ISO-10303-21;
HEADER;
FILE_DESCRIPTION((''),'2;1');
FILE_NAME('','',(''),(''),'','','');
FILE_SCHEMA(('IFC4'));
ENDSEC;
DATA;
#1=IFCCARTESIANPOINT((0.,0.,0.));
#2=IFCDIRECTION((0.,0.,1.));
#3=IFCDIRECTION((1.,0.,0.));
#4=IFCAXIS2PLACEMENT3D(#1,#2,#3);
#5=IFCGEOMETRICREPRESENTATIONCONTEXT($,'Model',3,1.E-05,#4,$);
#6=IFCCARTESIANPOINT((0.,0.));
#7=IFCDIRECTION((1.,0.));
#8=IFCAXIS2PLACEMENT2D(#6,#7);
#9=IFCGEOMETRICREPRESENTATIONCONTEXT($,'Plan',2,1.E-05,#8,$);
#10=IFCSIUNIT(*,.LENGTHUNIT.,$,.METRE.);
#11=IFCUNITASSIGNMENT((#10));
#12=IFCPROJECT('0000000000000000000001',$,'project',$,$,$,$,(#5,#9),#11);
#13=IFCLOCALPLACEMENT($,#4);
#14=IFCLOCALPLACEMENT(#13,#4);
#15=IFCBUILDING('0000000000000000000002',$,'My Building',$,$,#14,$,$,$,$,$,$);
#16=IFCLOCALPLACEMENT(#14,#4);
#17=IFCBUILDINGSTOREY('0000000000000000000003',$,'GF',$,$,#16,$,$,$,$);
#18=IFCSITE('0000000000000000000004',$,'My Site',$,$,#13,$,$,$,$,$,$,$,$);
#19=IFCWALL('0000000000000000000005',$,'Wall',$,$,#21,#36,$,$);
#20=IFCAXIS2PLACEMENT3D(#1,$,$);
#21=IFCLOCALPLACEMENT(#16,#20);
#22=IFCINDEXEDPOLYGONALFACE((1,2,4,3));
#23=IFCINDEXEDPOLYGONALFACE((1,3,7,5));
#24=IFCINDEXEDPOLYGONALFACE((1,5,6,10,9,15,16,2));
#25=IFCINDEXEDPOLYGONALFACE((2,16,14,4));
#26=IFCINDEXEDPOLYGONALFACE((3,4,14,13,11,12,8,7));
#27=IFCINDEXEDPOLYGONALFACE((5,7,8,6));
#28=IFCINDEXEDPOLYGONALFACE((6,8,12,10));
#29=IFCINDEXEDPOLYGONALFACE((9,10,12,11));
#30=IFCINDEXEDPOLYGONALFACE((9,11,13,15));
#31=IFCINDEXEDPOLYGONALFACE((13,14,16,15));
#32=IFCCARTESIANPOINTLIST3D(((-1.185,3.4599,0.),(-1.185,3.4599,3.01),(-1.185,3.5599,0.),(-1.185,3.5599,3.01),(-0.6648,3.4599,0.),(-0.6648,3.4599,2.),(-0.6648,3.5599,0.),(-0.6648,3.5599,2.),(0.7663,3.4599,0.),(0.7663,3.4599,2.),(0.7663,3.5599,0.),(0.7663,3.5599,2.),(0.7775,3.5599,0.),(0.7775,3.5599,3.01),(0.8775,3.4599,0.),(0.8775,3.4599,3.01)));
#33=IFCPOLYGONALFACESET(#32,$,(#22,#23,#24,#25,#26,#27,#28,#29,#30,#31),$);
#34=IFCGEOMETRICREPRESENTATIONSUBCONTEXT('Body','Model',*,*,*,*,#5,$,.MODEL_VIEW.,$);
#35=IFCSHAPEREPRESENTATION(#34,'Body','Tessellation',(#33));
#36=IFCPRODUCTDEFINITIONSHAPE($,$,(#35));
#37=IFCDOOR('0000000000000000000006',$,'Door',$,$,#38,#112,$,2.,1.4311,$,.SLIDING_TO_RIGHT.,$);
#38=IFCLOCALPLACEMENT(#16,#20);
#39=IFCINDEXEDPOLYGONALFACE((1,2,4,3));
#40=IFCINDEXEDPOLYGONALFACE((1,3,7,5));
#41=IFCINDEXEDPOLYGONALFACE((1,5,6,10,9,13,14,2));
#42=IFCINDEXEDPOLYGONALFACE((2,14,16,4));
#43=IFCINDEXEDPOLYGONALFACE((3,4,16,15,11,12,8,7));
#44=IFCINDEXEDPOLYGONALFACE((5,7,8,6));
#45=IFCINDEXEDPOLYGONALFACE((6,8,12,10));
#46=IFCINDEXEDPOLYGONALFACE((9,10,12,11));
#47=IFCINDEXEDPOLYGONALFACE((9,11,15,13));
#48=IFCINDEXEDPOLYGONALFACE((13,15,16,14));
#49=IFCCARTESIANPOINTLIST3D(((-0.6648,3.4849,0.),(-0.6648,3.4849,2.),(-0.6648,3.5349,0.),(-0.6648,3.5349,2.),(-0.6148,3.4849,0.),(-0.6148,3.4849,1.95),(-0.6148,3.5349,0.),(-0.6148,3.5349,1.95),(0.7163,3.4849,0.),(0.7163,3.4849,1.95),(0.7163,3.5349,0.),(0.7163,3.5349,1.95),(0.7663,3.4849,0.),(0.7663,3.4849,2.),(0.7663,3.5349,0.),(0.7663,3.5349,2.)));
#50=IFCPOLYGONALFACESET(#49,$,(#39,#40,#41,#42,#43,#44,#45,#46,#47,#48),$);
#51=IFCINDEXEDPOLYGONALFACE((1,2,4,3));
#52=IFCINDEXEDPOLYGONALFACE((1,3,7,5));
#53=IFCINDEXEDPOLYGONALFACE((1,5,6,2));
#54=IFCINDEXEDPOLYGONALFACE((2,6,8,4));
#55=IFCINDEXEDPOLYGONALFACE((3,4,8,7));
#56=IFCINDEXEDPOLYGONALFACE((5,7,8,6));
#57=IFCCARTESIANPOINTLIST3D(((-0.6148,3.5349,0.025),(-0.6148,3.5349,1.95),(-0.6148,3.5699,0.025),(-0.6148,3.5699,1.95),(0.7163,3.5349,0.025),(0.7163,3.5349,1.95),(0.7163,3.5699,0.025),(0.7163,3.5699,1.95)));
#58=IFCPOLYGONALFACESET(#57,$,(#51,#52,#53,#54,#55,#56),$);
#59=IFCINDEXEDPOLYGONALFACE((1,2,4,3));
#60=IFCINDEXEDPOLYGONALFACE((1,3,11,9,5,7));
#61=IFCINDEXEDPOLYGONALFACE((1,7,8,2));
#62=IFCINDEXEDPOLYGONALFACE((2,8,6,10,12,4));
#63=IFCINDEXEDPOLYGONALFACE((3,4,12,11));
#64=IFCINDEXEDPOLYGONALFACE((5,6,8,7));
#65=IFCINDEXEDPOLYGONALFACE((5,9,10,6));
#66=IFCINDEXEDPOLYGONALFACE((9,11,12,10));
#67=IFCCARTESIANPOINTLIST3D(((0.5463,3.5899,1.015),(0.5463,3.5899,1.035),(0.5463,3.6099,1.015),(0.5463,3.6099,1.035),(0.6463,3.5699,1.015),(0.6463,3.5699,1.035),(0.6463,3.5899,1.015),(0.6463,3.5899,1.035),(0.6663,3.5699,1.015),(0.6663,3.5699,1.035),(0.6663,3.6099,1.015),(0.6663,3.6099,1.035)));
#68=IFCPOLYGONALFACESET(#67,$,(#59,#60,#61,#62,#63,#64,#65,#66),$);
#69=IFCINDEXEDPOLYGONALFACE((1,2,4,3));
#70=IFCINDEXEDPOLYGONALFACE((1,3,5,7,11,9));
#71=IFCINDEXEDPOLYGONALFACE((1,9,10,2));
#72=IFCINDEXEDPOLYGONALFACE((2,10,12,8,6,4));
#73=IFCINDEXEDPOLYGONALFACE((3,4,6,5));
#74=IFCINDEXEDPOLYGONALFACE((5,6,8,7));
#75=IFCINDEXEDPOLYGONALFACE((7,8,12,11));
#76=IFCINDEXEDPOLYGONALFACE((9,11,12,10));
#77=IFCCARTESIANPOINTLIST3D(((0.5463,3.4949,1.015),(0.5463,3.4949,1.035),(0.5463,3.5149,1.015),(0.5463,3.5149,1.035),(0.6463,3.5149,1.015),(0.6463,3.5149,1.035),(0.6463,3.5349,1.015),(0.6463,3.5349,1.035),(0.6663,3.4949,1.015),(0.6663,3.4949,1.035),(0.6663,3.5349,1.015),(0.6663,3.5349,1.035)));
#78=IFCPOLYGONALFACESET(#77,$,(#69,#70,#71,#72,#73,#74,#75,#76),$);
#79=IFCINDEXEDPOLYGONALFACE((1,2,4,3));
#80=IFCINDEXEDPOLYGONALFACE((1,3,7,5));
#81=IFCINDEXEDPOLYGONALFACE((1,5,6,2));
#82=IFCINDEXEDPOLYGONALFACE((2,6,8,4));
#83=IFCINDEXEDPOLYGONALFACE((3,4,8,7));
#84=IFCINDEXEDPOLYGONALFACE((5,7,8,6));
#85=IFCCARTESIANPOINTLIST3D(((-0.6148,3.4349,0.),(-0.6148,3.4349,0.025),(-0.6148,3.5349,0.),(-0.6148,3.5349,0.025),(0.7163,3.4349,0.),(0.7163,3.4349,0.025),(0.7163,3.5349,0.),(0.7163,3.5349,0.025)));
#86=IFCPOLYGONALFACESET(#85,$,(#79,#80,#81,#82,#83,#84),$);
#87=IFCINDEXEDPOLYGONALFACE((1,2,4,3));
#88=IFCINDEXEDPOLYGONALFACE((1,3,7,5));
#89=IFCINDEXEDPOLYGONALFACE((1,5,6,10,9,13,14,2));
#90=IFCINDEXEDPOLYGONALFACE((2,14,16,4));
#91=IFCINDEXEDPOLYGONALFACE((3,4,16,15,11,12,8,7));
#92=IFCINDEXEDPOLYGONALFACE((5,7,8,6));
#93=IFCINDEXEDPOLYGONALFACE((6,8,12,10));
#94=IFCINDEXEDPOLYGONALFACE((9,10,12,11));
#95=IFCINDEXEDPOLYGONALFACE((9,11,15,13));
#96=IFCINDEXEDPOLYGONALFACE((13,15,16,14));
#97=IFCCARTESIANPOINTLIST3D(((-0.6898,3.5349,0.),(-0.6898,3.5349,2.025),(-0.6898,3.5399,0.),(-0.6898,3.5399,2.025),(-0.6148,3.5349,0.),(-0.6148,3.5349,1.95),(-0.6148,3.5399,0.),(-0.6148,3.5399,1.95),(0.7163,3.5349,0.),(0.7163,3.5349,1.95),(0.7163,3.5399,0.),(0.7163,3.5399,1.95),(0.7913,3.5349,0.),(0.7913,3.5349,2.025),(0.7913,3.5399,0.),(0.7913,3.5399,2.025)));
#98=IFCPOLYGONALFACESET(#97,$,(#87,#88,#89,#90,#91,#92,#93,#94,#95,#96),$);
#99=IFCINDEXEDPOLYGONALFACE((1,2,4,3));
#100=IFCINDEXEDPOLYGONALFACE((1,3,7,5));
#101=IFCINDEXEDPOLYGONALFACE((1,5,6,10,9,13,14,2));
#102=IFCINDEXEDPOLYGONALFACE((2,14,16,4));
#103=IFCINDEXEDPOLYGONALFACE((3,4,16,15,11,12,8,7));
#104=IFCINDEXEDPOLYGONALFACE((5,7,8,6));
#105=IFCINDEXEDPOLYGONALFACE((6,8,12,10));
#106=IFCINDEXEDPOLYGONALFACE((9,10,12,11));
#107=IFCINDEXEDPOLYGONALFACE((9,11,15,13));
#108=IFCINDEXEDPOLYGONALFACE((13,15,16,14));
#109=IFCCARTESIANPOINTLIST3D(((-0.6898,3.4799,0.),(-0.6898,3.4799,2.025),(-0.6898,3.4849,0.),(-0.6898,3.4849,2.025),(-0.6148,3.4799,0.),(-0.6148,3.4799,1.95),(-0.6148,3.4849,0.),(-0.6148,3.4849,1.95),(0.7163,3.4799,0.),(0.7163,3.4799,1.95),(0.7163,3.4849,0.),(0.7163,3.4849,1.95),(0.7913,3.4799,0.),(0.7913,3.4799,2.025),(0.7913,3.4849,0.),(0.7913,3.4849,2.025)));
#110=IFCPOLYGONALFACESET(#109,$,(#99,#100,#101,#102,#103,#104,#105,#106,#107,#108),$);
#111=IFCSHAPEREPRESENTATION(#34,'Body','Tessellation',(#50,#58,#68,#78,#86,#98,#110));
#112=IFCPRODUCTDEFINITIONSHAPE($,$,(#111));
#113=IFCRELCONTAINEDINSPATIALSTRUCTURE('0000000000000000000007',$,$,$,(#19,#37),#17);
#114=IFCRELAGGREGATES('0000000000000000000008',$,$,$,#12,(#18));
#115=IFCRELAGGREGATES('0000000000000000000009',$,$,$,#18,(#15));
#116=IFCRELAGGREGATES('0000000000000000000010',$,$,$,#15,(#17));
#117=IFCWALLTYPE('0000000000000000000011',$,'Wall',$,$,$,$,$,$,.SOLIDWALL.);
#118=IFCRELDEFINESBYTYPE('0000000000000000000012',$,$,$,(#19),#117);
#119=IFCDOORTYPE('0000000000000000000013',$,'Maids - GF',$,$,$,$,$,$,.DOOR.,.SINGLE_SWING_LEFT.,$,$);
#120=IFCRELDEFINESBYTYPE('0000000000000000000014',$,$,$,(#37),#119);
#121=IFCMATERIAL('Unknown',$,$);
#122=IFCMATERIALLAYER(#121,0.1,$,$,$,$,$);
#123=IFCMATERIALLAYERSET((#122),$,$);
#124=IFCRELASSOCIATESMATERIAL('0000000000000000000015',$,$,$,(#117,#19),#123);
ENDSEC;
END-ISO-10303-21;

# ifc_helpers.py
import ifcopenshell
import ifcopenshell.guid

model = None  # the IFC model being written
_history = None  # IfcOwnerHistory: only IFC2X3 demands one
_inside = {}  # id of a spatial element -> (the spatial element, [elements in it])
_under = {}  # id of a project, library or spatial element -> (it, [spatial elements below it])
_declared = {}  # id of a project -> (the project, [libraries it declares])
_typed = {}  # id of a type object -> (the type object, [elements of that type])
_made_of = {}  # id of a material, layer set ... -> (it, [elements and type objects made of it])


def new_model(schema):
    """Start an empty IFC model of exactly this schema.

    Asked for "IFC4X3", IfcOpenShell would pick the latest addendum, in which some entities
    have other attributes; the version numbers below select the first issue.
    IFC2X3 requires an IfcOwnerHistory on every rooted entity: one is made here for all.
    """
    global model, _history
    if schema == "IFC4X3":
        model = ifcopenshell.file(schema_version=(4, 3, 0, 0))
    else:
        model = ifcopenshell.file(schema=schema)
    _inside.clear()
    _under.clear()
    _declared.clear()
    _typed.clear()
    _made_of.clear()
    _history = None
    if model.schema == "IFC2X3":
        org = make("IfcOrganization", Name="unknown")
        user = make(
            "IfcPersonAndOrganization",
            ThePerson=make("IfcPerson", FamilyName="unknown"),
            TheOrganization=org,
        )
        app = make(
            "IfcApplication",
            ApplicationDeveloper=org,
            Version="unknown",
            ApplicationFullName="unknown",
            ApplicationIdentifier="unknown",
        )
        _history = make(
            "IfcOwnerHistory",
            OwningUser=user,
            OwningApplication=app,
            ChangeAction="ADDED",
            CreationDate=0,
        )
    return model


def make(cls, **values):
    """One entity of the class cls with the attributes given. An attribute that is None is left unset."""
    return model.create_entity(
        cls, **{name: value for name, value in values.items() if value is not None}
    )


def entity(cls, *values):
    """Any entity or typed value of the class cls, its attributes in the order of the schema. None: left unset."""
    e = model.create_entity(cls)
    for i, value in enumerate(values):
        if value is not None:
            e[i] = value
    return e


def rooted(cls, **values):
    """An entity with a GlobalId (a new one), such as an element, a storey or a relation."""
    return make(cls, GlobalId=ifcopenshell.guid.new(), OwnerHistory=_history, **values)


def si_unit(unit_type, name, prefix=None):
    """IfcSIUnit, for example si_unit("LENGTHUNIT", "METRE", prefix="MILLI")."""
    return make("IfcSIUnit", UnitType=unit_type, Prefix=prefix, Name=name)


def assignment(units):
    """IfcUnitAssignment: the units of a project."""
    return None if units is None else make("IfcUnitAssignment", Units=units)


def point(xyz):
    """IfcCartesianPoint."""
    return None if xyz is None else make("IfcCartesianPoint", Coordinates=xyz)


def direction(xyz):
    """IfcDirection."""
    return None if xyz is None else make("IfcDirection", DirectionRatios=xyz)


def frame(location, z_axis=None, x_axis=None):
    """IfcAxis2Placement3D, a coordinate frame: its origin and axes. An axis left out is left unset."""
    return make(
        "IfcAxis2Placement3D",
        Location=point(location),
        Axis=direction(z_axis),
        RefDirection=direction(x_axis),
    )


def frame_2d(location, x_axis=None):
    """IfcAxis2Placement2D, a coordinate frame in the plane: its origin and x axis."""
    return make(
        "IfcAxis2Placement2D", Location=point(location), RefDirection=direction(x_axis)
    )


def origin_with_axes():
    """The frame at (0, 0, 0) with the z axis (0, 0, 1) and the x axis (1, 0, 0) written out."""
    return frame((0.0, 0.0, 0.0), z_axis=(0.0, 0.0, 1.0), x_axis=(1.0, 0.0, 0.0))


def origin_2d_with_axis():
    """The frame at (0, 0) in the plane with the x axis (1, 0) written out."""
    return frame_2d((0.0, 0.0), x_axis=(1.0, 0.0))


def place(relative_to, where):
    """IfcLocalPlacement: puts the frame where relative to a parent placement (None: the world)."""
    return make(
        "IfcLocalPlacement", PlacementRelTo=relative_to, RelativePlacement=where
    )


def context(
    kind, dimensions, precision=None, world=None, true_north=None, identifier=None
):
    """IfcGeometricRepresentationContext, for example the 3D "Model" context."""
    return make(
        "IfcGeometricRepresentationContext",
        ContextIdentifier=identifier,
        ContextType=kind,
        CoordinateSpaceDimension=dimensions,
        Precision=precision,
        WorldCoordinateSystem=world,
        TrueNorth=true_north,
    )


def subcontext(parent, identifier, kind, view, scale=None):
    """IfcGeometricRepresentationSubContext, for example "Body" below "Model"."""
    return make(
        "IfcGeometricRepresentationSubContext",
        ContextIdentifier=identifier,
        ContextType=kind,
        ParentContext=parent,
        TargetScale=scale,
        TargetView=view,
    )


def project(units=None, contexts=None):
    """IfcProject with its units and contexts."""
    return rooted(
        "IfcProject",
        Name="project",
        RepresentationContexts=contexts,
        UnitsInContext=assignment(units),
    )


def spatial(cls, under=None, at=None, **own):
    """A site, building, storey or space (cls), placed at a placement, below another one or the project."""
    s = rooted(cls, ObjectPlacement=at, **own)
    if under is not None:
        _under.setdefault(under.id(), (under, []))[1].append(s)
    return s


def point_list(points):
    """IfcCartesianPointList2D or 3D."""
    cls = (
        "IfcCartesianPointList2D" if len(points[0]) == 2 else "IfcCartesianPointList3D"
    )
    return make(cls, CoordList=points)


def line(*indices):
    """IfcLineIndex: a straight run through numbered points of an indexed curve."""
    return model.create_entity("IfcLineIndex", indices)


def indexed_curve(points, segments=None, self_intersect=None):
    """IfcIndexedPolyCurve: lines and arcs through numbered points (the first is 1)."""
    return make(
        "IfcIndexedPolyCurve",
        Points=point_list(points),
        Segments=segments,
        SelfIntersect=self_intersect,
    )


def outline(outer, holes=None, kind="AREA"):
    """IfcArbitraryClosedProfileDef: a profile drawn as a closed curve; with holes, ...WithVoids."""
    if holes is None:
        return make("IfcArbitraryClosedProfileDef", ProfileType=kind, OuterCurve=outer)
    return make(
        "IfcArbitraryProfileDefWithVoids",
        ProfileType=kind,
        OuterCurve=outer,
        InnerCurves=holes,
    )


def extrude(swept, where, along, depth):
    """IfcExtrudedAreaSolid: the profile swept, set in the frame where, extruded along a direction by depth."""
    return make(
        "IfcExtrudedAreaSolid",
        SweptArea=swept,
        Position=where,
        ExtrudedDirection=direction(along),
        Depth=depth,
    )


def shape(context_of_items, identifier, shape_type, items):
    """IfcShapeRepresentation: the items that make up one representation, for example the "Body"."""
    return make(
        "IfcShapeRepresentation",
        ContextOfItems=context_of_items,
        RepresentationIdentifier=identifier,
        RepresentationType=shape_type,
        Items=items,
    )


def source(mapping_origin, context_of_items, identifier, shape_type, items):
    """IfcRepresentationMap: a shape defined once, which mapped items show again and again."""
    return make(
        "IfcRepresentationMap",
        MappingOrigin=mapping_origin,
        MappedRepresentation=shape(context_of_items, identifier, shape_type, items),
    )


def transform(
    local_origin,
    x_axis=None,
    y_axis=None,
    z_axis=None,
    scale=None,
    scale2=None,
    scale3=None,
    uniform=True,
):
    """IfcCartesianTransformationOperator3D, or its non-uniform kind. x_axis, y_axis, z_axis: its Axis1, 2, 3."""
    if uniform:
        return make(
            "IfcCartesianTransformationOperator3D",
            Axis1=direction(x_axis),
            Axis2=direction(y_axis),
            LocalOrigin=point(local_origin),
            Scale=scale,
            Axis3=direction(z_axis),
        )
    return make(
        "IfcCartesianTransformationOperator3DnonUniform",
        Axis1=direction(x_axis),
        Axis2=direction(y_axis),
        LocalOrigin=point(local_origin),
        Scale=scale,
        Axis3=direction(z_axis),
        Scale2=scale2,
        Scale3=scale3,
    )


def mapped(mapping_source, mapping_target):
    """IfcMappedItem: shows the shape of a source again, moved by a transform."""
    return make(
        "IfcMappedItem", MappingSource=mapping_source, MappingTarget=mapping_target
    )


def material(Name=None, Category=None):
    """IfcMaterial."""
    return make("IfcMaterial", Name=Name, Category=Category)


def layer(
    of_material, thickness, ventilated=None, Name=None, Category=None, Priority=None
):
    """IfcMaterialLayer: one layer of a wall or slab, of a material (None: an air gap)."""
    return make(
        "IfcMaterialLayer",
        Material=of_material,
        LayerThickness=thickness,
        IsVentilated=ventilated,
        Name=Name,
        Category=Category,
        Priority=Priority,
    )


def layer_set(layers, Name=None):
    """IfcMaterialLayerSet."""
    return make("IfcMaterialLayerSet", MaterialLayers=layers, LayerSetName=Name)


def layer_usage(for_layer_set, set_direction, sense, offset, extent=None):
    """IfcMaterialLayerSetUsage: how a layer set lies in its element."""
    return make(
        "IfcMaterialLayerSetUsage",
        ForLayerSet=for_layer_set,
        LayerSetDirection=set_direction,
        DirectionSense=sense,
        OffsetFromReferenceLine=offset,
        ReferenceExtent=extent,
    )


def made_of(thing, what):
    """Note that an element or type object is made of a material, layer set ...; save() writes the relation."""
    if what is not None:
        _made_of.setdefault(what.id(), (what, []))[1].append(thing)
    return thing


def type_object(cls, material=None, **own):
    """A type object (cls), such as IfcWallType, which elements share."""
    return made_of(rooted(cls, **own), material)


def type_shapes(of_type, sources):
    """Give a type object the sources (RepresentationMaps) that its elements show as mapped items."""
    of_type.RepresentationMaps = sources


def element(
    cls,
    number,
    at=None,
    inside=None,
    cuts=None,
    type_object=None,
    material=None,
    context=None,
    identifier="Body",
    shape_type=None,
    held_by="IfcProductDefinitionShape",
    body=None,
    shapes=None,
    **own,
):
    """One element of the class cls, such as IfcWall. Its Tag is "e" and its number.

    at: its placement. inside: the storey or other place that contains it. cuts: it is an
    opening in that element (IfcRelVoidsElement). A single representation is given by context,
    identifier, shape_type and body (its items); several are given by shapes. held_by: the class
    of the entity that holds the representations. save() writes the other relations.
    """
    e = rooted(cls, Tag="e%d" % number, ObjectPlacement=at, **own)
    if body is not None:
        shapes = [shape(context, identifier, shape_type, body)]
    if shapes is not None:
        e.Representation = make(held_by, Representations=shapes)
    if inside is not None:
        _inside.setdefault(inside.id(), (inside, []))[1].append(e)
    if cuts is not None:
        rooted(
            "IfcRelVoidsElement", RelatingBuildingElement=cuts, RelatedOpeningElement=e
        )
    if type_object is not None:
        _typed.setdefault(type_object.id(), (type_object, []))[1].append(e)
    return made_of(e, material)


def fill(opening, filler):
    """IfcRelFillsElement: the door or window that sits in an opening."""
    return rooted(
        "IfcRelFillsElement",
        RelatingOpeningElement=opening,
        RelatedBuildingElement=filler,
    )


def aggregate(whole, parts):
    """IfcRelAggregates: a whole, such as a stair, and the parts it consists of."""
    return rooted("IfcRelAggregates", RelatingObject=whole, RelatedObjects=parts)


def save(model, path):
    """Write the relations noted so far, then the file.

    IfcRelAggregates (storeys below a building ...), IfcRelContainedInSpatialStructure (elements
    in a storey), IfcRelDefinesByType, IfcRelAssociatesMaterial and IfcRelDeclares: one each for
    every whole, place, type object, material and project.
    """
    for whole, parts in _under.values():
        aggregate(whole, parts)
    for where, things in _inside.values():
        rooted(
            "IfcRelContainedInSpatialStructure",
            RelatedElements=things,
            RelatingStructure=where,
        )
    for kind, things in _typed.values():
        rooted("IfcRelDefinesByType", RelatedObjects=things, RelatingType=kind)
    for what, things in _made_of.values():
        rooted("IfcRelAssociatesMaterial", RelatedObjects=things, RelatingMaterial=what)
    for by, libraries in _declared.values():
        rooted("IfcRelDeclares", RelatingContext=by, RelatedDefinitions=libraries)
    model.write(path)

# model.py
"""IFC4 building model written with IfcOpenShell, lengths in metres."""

from ifc_helpers import new_model, entity, si_unit, frame, origin_with_axes, origin_2d_with_axis, place, context, subcontext, project, spatial, line, indexed_curve, outline, extrude, shape, source, transform, mapped, material, layer, layer_set, layer_usage, type_object, type_shapes, element, fill, save


model = new_model("IFC4")

# Units and contexts
model_context = context("Model", 3, precision=1e-05, world=origin_with_axes())
plan_context = context("Plan", 2, precision=1e-05, world=origin_2d_with_axis())
body_context_1 = subcontext(model_context, "Body", "Model", "MODEL_VIEW")
body_context_2 = subcontext(plan_context, "Body", "Plan", "PLAN_VIEW")
ifc_project = project(units=[si_unit("LENGTHUNIT", "METRE")], contexts=[model_context, plan_context])

# Site, building, storey
site_placement = place(None, origin_with_axes())
site = spatial("IfcSite", under=ifc_project, at=site_placement, Name="My Site")
building_placement = place(site_placement, origin_with_axes())
building = spatial("IfcBuilding", under=site, at=building_placement, Name="My Building")
storey_placement = place(building_placement, origin_with_axes())
storey = spatial("IfcBuildingStorey", under=building, at=storey_placement, Name="GF")

# Shared definitions
ifc_material_1 = material(Name="Unknown")

# Shared definitions
ifc_layer_1 = layer(ifc_material_1, 0.1)
ifc_layer_set_1 = layer_set([ifc_layer_1])
wall_type = type_object("IfcWallType", Name="Wall", PredefinedType="SOLIDWALL", material=ifc_layer_set_1)

# Wall, opening, door
ifc_layer_usage_1 = layer_usage(ifc_layer_set_1, "AXIS2", "POSITIVE", 0.0)
wall_1_placement = place(storey_placement, frame((0.7775, 3.5599, 0.0), z_axis=(0.0, 0.0, 1.0), x_axis=(-1.0, 0.0, 0.0)))
wall_1 = element("IfcWall", 1, at=wall_1_placement, inside=storey, type_object=wall_type, material=ifc_layer_usage_1, Name="Wall", context=body_context_1, shape_type="SweptSolid", body=[
    extrude(outline(indexed_curve([(0.0, 0.0), (-0.1, 0.1), (1.9625, 0.1), (1.9625, 0.0)], segments=[line(1, 2, 3, 4, 1)])), origin_with_axes(), (0.0, 0.0, 1.0), 3.01),
])
shared_shape_1 = source(origin_with_axes(), body_context_1, "Body", "SweptSolid", [
    extrude(outline(indexed_curve([(0.0, 0.0), (1.4311, 0.0), (1.4311, 2.0), (0.0, 2.0)], segments=[line(1, 2, 3, 4, 1)])), frame((0.0, -0.6, 0.0), z_axis=(0.0, -1.0, 0.0), x_axis=(1.0, 0.0, 0.0)), (0.0, 0.0, -1.0), 1.2),
])
opening_1_placement = place(wall_1_placement, frame((0.0111, 0.025, 0.0), z_axis=(0.0, 0.0, 1.0), x_axis=(1.0, -0.000001, 0.0)))
opening_1 = element("IfcOpeningElement", 2, at=opening_1_placement, cuts=wall_1, PredefinedType="OPENING", context=body_context_1, shape_type="MappedRepresentation", body=[
    mapped(shared_shape_1, transform((0.0, 0.0, 0.0), x_axis=(1.0, 0.0, 0.0), y_axis=(0.0, 1.0, 0.0), z_axis=(0.0, 0.0, 1.0), scale=1.0)),
])
door_type_1 = type_object("IfcDoorType", Name="Maids - GF", OperationType="SINGLE_SWING_LEFT", PredefinedType="DOOR")
shared_shape_2 = source(origin_with_axes(), body_context_1, "Body", "SweptSolid", [
    extrude(outline(indexed_curve([(0.0, 0.0), (0.0, 2.0), (1.4311, 2.0), (1.4311, 0.0), (1.3811, 0.0), (1.3811, 1.95), (0.05, 1.95), (0.05, 0.0)], segments=[line(1, 2, 3, 4, 5, 6, 7, 8, 1)])), frame((0.0, 0.0, 0.0), z_axis=(0.0, -1.0, 0.0), x_axis=(1.0, 0.0, 0.0)), (0.0, 0.0, -1.0), 0.05),
    extrude(outline(indexed_curve([(0.0, 0.0), (1.3311, 0.0), (1.3311, 0.035), (0.0, 0.035)], segments=[line(1, 2, 3, 4, 1)])), frame((0.05, -0.035, 0.025), z_axis=(0.0, 0.0, 1.0), x_axis=(1.0, 0.0, 0.0)), (0.0, 0.0, 1.0), 1.925),
    extrude(outline(indexed_curve([(0.0, 0.0), (0.0, -0.04), (0.12, -0.04), (0.12, -0.02), (0.02, -0.02), (0.02, 0.0)], segments=[line(1, 2, 3, 4, 5, 6, 1)])), frame((0.1, -0.035, 1.015), z_axis=(0.0, 0.0, 1.0), x_axis=(1.0, 0.0, 0.0)), (0.0, 0.0, 1.0), 0.02),
    extrude(outline(indexed_curve([(0.0, 0.0), (0.0, 0.04), (0.12, 0.04), (0.12, 0.02), (0.02, 0.02), (0.02, 0.0)], segments=[line(1, 2, 3, 4, 5, 6, 1)])), frame((0.1, 0.0, 1.015), z_axis=(0.0, 0.0, 1.0), x_axis=(1.0, 0.0, 0.0)), (0.0, 0.0, 1.0), 0.02),
    extrude(outline(indexed_curve([(0.0, 0.0), (1.3311, 0.0), (1.3311, 0.1), (0.0, 0.1)], segments=[line(1, 2, 3, 4, 1)])), frame((0.05, 0.0, 0.0), z_axis=(0.0, 0.0, 1.0), x_axis=(1.0, 0.0, 0.0)), (0.0, 0.0, 1.0), 0.025),
    extrude(outline(indexed_curve([(0.0, 0.0), (0.0, 2.025), (1.4811, 2.025), (1.4811, 0.0), (1.4061, 0.0), (1.4061, 1.95), (0.075, 1.95), (0.075, 0.0)], segments=[line(1, 2, 3, 4, 5, 6, 7, 8, 1)])), frame((-0.025, -0.005, 0.0), z_axis=(0.0, -1.0, 0.0), x_axis=(1.0, 0.0, 0.0)), (0.0, 0.0, -1.0), 0.005),
    extrude(outline(indexed_curve([(0.0, 0.0), (0.0, 2.025), (1.4811, 2.025), (1.4811, 0.0), (1.4061, 0.0), (1.4061, 1.95), (0.075, 1.95), (0.075, 0.0)], segments=[line(1, 2, 3, 4, 5, 6, 7, 8, 1)])), frame((-0.025, 0.05, 0.0), z_axis=(0.0, -1.0, 0.0), x_axis=(1.0, 0.0, 0.0)), (0.0, 0.0, -1.0), 0.005),
])
shared_shape_3 = source(origin_with_axes(), body_context_2, "Body", "Curve2D", [
    entity("IfcIndexedPolyCurve", entity("IfcCartesianPointList2D", [[0.0, 0.0], [0.05, 0.0], [0.05, 0.05], [0.0, 0.05]]), [entity("IfcLineIndex", [1, 2, 3, 4, 1])]),
    entity("IfcIndexedPolyCurve", entity("IfcCartesianPointList2D", [[1.4311, 0.0], [1.3811, 0.0], [1.3811, 0.05], [1.4311, 0.05]]), [entity("IfcLineIndex", [1, 2, 3, 4, 1])]),
    entity("IfcIndexedPolyCurve", entity("IfcCartesianPointList2D", [[2.0467, -0.035], [0.7156, -0.035], [0.7156, 0.0], [2.0467, 0.0]]), [entity("IfcLineIndex", [1, 2, 3, 4, 1])]),
])
type_shapes(door_type_1, [shared_shape_2, shared_shape_3])
door_1_placement = place(opening_1_placement, frame((0.0, 0.0, 0.0), z_axis=(0.0, 0.0, 1.0), x_axis=(1.0, 0.0, 0.0)))
door_1 = element("IfcDoor", 3, at=door_1_placement, inside=storey, type_object=door_type_1, Name="Door", OperationType="SLIDING_TO_RIGHT", OverallHeight=2.0, OverallWidth=1.4311, shapes=[
    shape(body_context_1, "Body", "MappedRepresentation", [mapped(shared_shape_2, transform((0.0, 0.0, 0.0), x_axis=(1.0, 0.0, 0.0), y_axis=(0.0, 1.0, 0.0), z_axis=(0.0, 0.0, 1.0), scale=1.0))]),
    shape(body_context_2, "Body", "MappedRepresentation", [mapped(shared_shape_3, transform((0.0, 0.0, 0.0), x_axis=(1.0, 0.0, 0.0), y_axis=(0.0, 1.0, 0.0), z_axis=(0.0, 0.0, 1.0), scale=1.0))]),
])
fill(opening_1, door_1)

save(model, "model.ifc")
